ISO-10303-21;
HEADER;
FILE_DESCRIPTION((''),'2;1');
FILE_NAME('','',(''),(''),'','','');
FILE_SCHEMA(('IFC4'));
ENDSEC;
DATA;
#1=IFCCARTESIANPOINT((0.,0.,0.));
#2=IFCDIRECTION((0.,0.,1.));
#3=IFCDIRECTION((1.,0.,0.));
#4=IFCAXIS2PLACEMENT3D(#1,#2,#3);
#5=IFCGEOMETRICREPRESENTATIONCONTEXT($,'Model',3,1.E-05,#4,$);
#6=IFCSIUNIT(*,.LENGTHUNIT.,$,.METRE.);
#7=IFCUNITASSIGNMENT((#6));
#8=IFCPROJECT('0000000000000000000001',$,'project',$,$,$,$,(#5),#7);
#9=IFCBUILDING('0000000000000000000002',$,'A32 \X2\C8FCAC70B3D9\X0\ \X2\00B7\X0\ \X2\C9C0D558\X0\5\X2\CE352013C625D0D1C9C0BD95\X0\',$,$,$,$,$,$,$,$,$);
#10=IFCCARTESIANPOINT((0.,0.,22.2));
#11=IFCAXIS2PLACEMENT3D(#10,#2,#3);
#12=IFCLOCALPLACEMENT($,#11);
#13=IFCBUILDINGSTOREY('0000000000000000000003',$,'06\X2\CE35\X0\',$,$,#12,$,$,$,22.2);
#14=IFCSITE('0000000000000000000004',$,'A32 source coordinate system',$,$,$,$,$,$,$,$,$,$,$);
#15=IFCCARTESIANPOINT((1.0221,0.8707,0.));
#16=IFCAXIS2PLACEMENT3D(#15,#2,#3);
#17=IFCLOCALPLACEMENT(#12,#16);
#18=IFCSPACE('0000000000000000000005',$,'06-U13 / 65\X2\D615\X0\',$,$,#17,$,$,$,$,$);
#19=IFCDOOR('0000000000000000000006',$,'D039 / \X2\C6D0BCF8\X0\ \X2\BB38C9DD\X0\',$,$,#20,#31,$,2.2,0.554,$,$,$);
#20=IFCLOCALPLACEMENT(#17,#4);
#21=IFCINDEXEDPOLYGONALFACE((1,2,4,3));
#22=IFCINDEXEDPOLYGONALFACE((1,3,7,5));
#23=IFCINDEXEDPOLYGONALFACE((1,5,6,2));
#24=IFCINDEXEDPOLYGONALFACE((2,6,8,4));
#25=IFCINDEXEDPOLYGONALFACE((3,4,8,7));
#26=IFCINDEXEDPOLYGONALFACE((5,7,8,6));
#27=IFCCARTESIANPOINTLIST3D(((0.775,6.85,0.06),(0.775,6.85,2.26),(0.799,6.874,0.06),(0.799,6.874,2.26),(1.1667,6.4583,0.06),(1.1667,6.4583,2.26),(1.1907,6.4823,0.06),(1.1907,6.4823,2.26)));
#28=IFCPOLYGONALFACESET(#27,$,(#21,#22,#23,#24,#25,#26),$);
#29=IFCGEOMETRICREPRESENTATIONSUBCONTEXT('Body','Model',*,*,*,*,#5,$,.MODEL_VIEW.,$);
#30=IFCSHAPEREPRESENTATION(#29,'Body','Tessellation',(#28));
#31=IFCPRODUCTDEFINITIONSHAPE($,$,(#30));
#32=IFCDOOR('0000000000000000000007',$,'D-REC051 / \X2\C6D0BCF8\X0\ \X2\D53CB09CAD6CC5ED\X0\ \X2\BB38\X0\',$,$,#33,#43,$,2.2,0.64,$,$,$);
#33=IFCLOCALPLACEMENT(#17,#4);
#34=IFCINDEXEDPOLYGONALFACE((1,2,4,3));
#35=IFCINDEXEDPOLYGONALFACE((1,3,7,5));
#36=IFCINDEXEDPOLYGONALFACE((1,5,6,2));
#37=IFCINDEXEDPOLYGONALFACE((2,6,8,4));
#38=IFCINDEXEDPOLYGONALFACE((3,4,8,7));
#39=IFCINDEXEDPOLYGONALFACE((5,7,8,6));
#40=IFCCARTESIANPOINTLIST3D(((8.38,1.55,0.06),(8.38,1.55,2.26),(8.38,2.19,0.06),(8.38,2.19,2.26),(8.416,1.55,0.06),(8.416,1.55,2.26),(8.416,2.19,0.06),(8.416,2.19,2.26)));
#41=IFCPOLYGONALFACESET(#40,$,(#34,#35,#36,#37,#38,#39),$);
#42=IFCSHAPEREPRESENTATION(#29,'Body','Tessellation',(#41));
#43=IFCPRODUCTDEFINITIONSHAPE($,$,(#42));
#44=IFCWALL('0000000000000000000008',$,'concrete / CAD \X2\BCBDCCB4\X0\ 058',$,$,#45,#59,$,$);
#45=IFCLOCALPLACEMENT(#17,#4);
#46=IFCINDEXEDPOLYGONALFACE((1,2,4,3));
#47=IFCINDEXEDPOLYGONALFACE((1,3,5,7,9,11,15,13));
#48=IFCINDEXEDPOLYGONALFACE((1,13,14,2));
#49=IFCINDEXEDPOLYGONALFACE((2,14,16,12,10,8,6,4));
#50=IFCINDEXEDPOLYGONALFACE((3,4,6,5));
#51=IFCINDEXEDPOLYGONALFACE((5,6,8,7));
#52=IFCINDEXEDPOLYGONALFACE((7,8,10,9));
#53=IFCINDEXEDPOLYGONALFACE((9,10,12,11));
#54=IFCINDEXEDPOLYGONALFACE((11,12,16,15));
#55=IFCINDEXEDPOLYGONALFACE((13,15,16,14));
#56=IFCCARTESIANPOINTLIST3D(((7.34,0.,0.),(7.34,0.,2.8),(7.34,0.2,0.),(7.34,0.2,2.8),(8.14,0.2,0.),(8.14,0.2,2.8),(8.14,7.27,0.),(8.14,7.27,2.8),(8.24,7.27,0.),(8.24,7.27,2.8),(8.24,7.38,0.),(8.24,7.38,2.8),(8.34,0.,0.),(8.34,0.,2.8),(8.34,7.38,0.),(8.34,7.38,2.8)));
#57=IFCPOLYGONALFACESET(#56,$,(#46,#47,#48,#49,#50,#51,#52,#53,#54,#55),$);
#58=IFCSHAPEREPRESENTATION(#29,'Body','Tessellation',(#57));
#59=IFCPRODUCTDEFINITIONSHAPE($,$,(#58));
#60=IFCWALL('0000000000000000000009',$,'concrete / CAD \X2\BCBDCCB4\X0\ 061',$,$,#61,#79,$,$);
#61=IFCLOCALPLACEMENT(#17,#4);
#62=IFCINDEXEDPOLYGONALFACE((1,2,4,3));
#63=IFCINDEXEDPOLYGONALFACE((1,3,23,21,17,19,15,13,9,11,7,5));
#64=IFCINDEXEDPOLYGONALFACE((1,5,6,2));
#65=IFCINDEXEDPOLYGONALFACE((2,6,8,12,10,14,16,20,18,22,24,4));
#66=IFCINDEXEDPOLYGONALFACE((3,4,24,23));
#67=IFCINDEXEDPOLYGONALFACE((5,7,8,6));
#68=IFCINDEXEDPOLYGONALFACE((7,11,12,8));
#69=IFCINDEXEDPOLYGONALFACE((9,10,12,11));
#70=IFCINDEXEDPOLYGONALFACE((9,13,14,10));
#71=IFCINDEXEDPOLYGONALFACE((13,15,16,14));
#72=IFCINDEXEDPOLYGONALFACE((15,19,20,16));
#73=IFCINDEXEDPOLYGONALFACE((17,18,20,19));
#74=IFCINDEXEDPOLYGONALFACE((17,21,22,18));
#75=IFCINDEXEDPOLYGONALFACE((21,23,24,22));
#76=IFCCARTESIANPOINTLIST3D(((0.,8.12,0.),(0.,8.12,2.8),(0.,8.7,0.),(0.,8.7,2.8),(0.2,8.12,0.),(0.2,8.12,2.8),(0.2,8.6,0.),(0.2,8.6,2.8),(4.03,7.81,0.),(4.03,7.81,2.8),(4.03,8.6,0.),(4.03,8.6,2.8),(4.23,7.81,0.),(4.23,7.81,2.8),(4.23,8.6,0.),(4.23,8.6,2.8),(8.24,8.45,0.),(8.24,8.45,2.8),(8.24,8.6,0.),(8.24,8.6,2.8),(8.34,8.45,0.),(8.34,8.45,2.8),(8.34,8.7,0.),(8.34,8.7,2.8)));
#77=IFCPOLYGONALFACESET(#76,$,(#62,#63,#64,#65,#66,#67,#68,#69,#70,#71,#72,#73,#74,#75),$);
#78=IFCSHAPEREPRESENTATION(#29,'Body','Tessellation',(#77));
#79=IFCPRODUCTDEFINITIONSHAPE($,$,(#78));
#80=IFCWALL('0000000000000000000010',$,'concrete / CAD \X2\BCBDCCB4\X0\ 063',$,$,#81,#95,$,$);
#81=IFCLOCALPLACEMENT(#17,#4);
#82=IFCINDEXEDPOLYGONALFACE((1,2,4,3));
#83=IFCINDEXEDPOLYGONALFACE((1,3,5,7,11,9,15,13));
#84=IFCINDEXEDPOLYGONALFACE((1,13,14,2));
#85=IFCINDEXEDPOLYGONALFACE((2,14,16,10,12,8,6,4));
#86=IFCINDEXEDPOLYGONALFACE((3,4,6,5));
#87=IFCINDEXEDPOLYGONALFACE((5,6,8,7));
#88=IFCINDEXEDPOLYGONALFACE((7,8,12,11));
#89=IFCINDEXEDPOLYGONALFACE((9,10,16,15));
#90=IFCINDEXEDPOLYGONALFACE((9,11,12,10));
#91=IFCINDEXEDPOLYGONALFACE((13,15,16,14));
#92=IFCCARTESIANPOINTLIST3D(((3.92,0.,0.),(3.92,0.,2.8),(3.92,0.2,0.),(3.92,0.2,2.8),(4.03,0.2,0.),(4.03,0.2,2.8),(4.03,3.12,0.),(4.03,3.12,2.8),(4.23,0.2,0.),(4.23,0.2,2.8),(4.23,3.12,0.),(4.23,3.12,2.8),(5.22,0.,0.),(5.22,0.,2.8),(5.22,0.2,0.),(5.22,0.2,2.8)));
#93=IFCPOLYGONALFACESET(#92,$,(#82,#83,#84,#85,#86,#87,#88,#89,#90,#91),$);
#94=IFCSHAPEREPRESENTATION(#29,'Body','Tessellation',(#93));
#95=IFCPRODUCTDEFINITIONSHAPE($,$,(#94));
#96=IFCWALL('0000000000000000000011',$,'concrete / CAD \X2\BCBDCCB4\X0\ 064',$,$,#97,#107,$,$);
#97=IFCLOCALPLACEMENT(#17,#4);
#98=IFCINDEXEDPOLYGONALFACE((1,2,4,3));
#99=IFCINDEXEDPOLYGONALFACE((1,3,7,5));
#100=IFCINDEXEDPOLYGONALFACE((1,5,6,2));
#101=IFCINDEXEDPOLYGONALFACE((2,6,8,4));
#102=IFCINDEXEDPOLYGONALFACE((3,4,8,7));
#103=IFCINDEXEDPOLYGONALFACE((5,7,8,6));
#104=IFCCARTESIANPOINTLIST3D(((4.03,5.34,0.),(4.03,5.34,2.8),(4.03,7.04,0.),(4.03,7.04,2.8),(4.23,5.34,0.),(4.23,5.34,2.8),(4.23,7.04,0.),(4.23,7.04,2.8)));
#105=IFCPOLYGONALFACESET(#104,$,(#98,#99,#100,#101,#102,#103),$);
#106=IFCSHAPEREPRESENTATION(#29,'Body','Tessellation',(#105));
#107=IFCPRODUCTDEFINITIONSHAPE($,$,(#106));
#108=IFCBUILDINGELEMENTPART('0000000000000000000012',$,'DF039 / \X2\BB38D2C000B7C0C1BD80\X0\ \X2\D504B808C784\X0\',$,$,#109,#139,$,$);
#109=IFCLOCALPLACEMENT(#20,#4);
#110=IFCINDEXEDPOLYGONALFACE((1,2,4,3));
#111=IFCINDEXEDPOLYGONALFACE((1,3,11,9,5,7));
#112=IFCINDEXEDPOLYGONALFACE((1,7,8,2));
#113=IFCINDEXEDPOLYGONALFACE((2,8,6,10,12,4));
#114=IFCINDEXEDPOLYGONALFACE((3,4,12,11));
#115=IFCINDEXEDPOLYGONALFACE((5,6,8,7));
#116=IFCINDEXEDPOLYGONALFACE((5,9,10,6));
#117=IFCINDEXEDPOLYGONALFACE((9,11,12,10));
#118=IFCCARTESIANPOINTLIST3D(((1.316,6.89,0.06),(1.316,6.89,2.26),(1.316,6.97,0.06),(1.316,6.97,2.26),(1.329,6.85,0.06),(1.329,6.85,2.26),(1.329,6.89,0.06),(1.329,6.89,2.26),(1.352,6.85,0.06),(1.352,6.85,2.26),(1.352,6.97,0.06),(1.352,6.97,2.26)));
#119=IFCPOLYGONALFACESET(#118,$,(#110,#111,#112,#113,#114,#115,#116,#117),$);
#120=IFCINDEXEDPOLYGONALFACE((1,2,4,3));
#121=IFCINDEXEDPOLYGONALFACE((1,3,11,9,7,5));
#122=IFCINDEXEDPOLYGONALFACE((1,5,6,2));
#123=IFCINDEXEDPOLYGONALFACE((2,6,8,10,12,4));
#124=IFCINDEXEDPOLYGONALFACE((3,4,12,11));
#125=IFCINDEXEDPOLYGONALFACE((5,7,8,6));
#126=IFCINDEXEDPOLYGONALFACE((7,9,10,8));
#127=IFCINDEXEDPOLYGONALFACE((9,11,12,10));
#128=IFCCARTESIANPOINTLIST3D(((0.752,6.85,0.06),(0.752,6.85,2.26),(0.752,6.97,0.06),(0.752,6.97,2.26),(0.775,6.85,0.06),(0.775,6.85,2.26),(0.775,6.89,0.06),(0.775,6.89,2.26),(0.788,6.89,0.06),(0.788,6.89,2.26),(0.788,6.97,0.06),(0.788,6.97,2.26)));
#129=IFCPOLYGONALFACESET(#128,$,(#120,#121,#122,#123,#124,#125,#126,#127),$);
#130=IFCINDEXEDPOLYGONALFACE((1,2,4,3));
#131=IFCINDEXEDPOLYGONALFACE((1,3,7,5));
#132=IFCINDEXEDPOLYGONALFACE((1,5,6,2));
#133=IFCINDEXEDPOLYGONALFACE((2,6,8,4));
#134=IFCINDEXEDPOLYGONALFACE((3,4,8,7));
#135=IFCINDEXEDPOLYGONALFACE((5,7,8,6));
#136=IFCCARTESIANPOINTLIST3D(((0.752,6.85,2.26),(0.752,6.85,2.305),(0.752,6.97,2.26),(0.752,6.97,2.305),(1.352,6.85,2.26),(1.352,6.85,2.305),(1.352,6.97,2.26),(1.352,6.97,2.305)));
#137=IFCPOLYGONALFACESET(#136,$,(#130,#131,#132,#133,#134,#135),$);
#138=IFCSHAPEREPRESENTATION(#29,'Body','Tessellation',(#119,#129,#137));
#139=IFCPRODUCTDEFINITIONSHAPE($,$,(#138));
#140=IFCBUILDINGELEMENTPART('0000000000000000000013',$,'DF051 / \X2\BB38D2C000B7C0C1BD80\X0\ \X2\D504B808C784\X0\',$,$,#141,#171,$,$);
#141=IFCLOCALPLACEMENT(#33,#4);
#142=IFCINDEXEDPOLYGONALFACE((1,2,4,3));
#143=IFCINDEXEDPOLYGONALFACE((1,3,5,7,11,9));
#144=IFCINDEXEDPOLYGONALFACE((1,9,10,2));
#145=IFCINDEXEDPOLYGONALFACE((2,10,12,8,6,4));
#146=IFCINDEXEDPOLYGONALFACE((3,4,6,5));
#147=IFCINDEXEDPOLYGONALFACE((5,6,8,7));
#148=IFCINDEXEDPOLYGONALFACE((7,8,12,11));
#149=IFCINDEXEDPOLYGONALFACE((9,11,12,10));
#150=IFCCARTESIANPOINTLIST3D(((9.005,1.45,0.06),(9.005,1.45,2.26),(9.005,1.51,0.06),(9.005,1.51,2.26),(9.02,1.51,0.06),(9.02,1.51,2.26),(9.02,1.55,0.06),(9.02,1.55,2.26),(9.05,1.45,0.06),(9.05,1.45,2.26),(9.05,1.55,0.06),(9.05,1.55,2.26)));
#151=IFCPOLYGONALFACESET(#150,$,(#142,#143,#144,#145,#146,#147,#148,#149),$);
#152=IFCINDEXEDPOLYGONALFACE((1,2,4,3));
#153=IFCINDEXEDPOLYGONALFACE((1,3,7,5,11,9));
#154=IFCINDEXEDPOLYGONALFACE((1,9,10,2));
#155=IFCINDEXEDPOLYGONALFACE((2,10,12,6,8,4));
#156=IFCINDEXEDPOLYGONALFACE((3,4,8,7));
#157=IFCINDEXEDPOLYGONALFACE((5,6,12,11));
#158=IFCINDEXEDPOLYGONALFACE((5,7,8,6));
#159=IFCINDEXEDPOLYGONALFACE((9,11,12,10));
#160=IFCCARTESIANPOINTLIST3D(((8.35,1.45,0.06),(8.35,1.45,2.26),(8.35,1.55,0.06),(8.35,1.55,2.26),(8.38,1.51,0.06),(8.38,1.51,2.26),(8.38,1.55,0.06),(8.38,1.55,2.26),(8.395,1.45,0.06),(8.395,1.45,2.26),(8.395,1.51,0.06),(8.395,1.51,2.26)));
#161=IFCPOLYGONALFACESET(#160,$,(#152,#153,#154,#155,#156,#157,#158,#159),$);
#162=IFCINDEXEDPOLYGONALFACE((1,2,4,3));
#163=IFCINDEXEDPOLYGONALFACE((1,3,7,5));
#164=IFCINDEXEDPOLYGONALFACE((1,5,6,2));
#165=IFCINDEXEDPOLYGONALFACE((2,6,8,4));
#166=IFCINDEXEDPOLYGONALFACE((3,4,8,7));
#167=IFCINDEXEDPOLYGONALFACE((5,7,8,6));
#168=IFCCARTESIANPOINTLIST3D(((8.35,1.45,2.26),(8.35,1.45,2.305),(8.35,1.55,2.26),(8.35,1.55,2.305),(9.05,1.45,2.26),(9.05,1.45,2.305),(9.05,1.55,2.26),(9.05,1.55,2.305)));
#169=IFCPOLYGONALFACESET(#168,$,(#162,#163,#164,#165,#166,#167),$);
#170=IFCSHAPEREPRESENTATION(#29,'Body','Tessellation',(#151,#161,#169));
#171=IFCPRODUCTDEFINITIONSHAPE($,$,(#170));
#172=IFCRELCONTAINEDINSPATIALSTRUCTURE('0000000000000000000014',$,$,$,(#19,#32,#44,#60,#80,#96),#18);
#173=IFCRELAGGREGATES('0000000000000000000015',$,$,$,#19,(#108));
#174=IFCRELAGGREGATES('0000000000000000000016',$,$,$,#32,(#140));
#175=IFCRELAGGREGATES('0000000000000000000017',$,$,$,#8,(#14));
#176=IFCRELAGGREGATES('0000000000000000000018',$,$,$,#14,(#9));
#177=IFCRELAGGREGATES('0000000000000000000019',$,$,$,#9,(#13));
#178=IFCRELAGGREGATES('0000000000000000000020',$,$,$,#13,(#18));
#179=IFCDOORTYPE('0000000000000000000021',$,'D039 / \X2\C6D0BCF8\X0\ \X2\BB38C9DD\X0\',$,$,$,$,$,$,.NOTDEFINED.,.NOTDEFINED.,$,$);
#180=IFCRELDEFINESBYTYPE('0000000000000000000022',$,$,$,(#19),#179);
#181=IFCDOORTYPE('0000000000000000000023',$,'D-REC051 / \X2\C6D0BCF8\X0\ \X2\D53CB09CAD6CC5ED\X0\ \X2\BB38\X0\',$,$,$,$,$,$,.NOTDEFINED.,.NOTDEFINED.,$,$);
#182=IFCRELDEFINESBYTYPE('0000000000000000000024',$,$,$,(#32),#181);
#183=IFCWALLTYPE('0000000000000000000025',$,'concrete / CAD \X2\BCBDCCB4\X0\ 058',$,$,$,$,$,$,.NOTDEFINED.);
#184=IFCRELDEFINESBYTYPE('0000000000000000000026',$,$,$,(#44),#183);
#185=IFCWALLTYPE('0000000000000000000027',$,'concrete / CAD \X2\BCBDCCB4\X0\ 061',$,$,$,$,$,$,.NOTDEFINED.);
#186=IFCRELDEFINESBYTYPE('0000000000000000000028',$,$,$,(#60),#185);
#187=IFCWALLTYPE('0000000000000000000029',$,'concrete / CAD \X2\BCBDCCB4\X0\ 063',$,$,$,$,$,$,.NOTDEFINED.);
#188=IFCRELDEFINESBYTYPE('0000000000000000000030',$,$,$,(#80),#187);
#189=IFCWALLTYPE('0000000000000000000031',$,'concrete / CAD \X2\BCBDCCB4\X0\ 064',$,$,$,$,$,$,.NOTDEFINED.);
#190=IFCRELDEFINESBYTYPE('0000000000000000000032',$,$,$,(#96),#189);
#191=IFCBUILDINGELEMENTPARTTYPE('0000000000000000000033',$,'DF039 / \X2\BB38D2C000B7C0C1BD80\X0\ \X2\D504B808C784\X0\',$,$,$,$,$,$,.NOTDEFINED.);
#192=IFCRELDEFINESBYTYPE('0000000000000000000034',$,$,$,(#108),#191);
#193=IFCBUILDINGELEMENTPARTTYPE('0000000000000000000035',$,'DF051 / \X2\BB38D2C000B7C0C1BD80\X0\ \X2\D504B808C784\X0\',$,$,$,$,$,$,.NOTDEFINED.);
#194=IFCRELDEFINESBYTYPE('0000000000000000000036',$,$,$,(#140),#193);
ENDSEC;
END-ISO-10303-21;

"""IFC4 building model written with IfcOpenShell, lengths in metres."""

from ifc_helpers import new_model, si_unit, frame, origin, origin_with_axes, place, context, subcontext, project, spatial, polyline, outline, extrude, source, transform, mapped, type_object, type_shapes, element, aggregate, save


model = new_model("IFC4")

# Units and contexts
model_context = context("Model", 3, precision=1e-05, world=origin_with_axes())
body_context = subcontext(model_context, "Body", "Model", "MODEL_VIEW")
ifc_project = project(units=[si_unit("LENGTHUNIT", "METRE")], contexts=[model_context])

# Site, building, storey, space
storey_placement = place(None, frame((0.0, 0.0, 22.2), z_axis=(0.0, 0.0, 1.0), x_axis=(1.0, 0.0, 0.0)))
space_placement = place(storey_placement, frame((1.0221, 0.8707, 0.0), z_axis=(0.0, 0.0, 1.0), x_axis=(1.0, 0.0, 0.0)))
site = spatial("IfcSite", under=ifc_project, Name="A32 source coordinate system")
building = spatial("IfcBuilding", under=site, Name="A32 주거동 · 지하5층–옥탑지붕")
storey = spatial("IfcBuildingStorey", under=building, at=storey_placement, Name="06층", Elevation=22.2)
space = spatial("IfcSpace", under=storey, at=space_placement, Name="06-U13 / 65형")

# Doors
door_type_1 = type_object("IfcDoorType", Name="D039 / 원본 문짝", OperationType="NOTDEFINED", PredefinedType="NOTDEFINED")
shared_shape_1 = source(origin(), body_context, "Body", "SweptSolid", [
    extrude(outline(polyline([(1.1907, 6.4823), (1.1667, 6.4583), (0.775, 6.85), (0.799, 6.874), (1.1907, 6.4823)])), frame((0.0, 0.0, 0.06)), (0.0, 0.0, 1.0), 2.2),
])
type_shapes(door_type_1, [shared_shape_1])
door_1_placement = place(space_placement, origin_with_axes())
door_1 = element("IfcDoor", 1, at=door_1_placement, inside=space, type_object=door_type_1, Name="D039 / 원본 문짝", OverallHeight=2.2, OverallWidth=0.554, context=body_context, shape_type="MappedRepresentation", body=[
    mapped(shared_shape_1, transform((0.0, 0.0, 0.0), scale=1.0)),
])
door_type_2 = type_object("IfcDoorType", Name="D-REC051 / 원본 피난구역 문", OperationType="NOTDEFINED", PredefinedType="NOTDEFINED")
shared_shape_2 = source(origin(), body_context, "Body", "SweptSolid", [
    extrude(outline(polyline([(8.416, 2.19), (8.416, 1.55), (8.38, 1.55), (8.38, 2.19), (8.416, 2.19)])), frame((0.0, 0.0, 0.06)), (0.0, 0.0, 1.0), 2.2),
])
type_shapes(door_type_2, [shared_shape_2])
door_2_placement = place(space_placement, origin_with_axes())
door_2 = element("IfcDoor", 2, at=door_2_placement, inside=space, type_object=door_type_2, Name="D-REC051 / 원본 피난구역 문", OverallHeight=2.2, OverallWidth=0.64, context=body_context, shape_type="MappedRepresentation", body=[
    mapped(shared_shape_2, transform((0.0, 0.0, 0.0), scale=1.0)),
])

# Walls
wall_type_1 = type_object("IfcWallType", Name="concrete / CAD 벽체 058", PredefinedType="NOTDEFINED")
shared_shape_3 = source(origin(), body_context, "Body", "SweptSolid", [
    extrude(outline(polyline([(8.34, 0.0), (7.34, 0.0), (7.34, 0.2), (8.14, 0.2), (8.14, 7.27), (8.24, 7.27), (8.24, 7.38), (8.34, 7.38), (8.34, 0.0)])), origin(), (0.0, 0.0, 1.0), 2.8),
])
type_shapes(wall_type_1, [shared_shape_3])
wall_1_placement = place(space_placement, origin_with_axes())
element("IfcWall", 3, at=wall_1_placement, inside=space, type_object=wall_type_1, Name="concrete / CAD 벽체 058", context=body_context, shape_type="MappedRepresentation", body=[
    mapped(shared_shape_3, transform((0.0, 0.0, 0.0), scale=1.0)),
])
wall_type_2 = type_object("IfcWallType", Name="concrete / CAD 벽체 061", PredefinedType="NOTDEFINED")
shared_shape_4 = source(origin(), body_context, "Body", "SweptSolid", [
    extrude(outline(polyline([(0.2, 8.6), (0.2, 8.12), (0.0, 8.12), (0.0, 8.7), (8.34, 8.7), (8.34, 8.45), (8.24, 8.45), (8.24, 8.6), (4.23, 8.6), (4.23, 7.81), (4.03, 7.81), (4.03, 8.6), (0.2, 8.6)])), origin(), (0.0, 0.0, 1.0), 2.8),
])
type_shapes(wall_type_2, [shared_shape_4])
wall_2_placement = place(space_placement, origin_with_axes())
element("IfcWall", 4, at=wall_2_placement, inside=space, type_object=wall_type_2, Name="concrete / CAD 벽체 061", context=body_context, shape_type="MappedRepresentation", body=[
    mapped(shared_shape_4, transform((0.0, 0.0, 0.0), scale=1.0)),
])
wall_type_3 = type_object("IfcWallType", Name="concrete / CAD 벽체 063", PredefinedType="NOTDEFINED")
shared_shape_5 = source(origin(), body_context, "Body", "SweptSolid", [
    extrude(outline(polyline([(5.22, 0.0), (3.92, 0.0), (3.92, 0.2), (4.03, 0.2), (4.03, 3.12), (4.23, 3.12), (4.23, 0.2), (5.22, 0.2), (5.22, 0.0)])), origin(), (0.0, 0.0, 1.0), 2.8),
])
type_shapes(wall_type_3, [shared_shape_5])
wall_3_placement = place(space_placement, origin_with_axes())
element("IfcWall", 5, at=wall_3_placement, inside=space, type_object=wall_type_3, Name="concrete / CAD 벽체 063", context=body_context, shape_type="MappedRepresentation", body=[
    mapped(shared_shape_5, transform((0.0, 0.0, 0.0), scale=1.0)),
])
wall_type_4 = type_object("IfcWallType", Name="concrete / CAD 벽체 064", PredefinedType="NOTDEFINED")
shared_shape_6 = source(origin(), body_context, "Body", "SweptSolid", [
    extrude(outline(polyline([(4.03, 7.04), (4.23, 7.04), (4.23, 5.34), (4.03, 5.34), (4.03, 7.04)])), origin(), (0.0, 0.0, 1.0), 2.8),
])
type_shapes(wall_type_4, [shared_shape_6])
wall_4_placement = place(space_placement, origin_with_axes())
element("IfcWall", 6, at=wall_4_placement, inside=space, type_object=wall_type_4, Name="concrete / CAD 벽체 064", context=body_context, shape_type="MappedRepresentation", body=[
    mapped(shared_shape_6, transform((0.0, 0.0, 0.0), scale=1.0)),
])

# Building element parts
building_element_part_type_1 = type_object("IfcBuildingElementPartType", Name="DF039 / 문틀·상부 프레임", PredefinedType="NOTDEFINED")
shared_shape_7 = source(origin(), body_context, "Body", "SweptSolid", [
    extrude(outline(polyline([(1.352, 6.85), (1.329, 6.85), (1.329, 6.89), (1.316, 6.89), (1.316, 6.97), (1.352, 6.97), (1.352, 6.85)])), frame((0.0, 0.0, 0.06)), (0.0, 0.0, 1.0), 2.2),
    extrude(outline(polyline([(0.788, 6.97), (0.788, 6.89), (0.775, 6.89), (0.775, 6.85), (0.752, 6.85), (0.752, 6.97), (0.788, 6.97)])), frame((0.0, 0.0, 0.06)), (0.0, 0.0, 1.0), 2.2),
    extrude(outline(polyline([(0.752, 6.85), (0.752, 6.97), (1.352, 6.97), (1.352, 6.85), (0.752, 6.85)])), frame((0.0, 0.0, 2.26)), (0.0, 0.0, 1.0), 0.045),
])
type_shapes(building_element_part_type_1, [shared_shape_7])
building_element_part_1_placement = place(door_1_placement, origin_with_axes())
building_element_part_1 = element("IfcBuildingElementPart", 7, at=building_element_part_1_placement, type_object=building_element_part_type_1, Name="DF039 / 문틀·상부 프레임", context=body_context, shape_type="MappedRepresentation", body=[
    mapped(shared_shape_7, transform((0.0, 0.0, 0.0), scale=1.0)),
])
aggregate(door_1, [building_element_part_1])
building_element_part_type_2 = type_object("IfcBuildingElementPartType", Name="DF051 / 문틀·상부 프레임", PredefinedType="NOTDEFINED")
shared_shape_8 = source(origin(), body_context, "Body", "SweptSolid", [
    extrude(outline(polyline([(9.05, 1.45), (9.005, 1.45), (9.005, 1.51), (9.02, 1.51), (9.02, 1.55), (9.05, 1.55), (9.05, 1.45)])), frame((0.0, 0.0, 0.06)), (0.0, 0.0, 1.0), 2.2),
    extrude(outline(polyline([(8.38, 1.55), (8.38, 1.51), (8.395, 1.51), (8.395, 1.45), (8.35, 1.45), (8.35, 1.55), (8.38, 1.55)])), frame((0.0, 0.0, 0.06)), (0.0, 0.0, 1.0), 2.2),
    extrude(outline(polyline([(8.35, 1.45), (8.35, 1.55), (9.05, 1.55), (9.05, 1.45), (8.35, 1.45)])), frame((0.0, 0.0, 2.26)), (0.0, 0.0, 1.0), 0.045),
])
type_shapes(building_element_part_type_2, [shared_shape_8])
building_element_part_2_placement = place(door_2_placement, origin_with_axes())
building_element_part_2 = element("IfcBuildingElementPart", 8, at=building_element_part_2_placement, type_object=building_element_part_type_2, Name="DF051 / 문틀·상부 프레임", context=body_context, shape_type="MappedRepresentation", body=[
    mapped(shared_shape_8, transform((0.0, 0.0, 0.0), scale=1.0)),
])
aggregate(door_2, [building_element_part_2])

save(model, "model.ifc")
